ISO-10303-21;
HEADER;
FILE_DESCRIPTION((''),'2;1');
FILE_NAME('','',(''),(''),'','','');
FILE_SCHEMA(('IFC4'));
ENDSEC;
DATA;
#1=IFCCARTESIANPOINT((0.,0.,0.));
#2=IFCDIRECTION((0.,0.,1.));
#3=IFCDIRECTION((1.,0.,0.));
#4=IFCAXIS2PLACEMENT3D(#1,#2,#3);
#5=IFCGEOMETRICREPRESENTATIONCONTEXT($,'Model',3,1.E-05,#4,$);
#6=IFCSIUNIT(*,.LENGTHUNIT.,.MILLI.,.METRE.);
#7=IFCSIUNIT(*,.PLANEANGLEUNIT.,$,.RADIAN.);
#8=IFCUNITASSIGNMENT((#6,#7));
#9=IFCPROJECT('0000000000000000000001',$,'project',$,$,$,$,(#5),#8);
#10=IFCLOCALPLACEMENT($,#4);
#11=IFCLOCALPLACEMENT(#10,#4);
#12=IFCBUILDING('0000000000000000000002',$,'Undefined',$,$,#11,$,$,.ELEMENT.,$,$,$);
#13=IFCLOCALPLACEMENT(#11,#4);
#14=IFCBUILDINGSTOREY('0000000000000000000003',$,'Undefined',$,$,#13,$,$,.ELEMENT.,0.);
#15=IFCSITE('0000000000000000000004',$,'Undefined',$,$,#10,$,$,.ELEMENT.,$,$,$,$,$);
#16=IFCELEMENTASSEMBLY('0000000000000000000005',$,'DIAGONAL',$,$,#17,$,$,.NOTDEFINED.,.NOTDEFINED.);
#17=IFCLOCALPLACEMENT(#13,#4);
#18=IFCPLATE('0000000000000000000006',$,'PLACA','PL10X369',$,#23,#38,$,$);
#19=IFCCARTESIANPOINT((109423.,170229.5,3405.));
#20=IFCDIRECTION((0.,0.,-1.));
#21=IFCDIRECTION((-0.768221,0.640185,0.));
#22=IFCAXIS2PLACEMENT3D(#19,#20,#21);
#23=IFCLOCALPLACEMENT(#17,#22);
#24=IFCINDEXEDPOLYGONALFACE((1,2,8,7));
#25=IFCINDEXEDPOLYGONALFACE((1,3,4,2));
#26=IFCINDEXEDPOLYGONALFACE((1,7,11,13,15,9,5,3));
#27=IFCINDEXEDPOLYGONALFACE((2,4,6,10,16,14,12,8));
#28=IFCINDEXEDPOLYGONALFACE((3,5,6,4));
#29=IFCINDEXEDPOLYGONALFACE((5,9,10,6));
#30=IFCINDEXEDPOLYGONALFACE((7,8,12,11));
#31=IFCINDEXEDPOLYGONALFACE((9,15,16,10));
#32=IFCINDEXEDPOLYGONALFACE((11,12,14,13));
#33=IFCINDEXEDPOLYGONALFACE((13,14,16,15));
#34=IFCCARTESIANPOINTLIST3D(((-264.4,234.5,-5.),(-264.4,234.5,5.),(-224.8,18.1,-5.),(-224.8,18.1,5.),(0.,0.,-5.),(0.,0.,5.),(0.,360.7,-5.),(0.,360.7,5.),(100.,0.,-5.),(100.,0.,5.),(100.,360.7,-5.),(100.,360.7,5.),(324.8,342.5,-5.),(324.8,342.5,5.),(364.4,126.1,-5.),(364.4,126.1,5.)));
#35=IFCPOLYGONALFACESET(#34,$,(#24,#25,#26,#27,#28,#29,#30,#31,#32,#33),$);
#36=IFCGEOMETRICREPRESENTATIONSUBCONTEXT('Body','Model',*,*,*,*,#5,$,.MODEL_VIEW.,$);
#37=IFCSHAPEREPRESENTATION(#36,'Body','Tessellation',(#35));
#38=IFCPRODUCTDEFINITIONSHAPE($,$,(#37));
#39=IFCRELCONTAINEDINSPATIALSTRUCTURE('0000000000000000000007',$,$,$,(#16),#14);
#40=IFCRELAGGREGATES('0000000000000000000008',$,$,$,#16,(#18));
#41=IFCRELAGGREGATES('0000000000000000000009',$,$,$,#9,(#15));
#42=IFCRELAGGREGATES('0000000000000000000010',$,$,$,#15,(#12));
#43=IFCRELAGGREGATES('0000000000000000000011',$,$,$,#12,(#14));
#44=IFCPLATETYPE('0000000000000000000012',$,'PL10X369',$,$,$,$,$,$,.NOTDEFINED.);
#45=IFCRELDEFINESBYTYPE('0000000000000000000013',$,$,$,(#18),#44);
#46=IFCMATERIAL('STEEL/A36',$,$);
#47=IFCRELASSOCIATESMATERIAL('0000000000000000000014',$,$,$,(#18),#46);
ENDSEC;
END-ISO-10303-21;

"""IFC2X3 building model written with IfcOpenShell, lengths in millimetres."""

from ifc_helpers import new_model, si_unit, frame, origin_with_axes, place, context, subcontext, project, spatial, polyline, outline, extrude, material, type_object, element, aggregate, save


model = new_model("IFC2X3")

# Units and contexts
model_context = context("Model", 3, precision=1e-05, world=origin_with_axes())
body_context = subcontext(model_context, "Body", "Model", "MODEL_VIEW")
ifc_project = project(units=[si_unit("LENGTHUNIT", "METRE", prefix="MILLI"), si_unit("PLANEANGLEUNIT", "RADIAN")], contexts=[model_context])

# Site, building, storey
site_placement = place(None, origin_with_axes())
site = spatial("IfcSite", under=ifc_project, at=site_placement, Name="Undefined", CompositionType="ELEMENT")
building_placement = place(site_placement, origin_with_axes())
building = spatial("IfcBuilding", under=site, at=building_placement, Name="Undefined", CompositionType="ELEMENT")
storey_placement = place(building_placement, origin_with_axes())
storey = spatial("IfcBuildingStorey", under=building, at=storey_placement, Name="Undefined", CompositionType="ELEMENT", Elevation=0.0)

# Shared definitions
ifc_material_1 = material(Name="STEEL/A36")

# Element assembly
assembly_1_placement = place(storey_placement, origin_with_axes())
assembly_1 = element("IfcElementAssembly", 1, at=assembly_1_placement, inside=storey, Name="DIAGONAL", AssemblyPlace="NOTDEFINED", PredefinedType="NOTDEFINED")

# Plate
plate_type_1 = type_object("IfcPlateType", Name="PL10X369", PredefinedType="NOTDEFINED")
plate_1_placement = place(assembly_1_placement, frame((109423.0, 170229.5, 3405.0), z_axis=(0.0, 0.0, -1.0), x_axis=(-0.768221, 0.640185, 0.0)))
plate_1 = element("IfcPlate", 2, at=plate_1_placement, type_object=plate_type_1, material=ifc_material_1, Name="PLACA", Description="PL10X369", context=body_context, shape_type="SweptSolid", body=[
    extrude(outline(polyline([(0.0, 0.0), (100.0, 0.0), (364.4, 126.1), (324.8, 342.5), (100.0, 360.7), (0.0, 360.7), (-264.4, 234.5), (-224.8, 18.1), (0.0, 0.0)])), frame((0.0, 0.0, -5.0), z_axis=(0.0, 0.0, 1.0), x_axis=(1.0, 0.0, 0.0)), (0.0, 0.0, 1.0), 10.0),
])

aggregate(assembly_1, [plate_1])

save(model, "model.ifc")
